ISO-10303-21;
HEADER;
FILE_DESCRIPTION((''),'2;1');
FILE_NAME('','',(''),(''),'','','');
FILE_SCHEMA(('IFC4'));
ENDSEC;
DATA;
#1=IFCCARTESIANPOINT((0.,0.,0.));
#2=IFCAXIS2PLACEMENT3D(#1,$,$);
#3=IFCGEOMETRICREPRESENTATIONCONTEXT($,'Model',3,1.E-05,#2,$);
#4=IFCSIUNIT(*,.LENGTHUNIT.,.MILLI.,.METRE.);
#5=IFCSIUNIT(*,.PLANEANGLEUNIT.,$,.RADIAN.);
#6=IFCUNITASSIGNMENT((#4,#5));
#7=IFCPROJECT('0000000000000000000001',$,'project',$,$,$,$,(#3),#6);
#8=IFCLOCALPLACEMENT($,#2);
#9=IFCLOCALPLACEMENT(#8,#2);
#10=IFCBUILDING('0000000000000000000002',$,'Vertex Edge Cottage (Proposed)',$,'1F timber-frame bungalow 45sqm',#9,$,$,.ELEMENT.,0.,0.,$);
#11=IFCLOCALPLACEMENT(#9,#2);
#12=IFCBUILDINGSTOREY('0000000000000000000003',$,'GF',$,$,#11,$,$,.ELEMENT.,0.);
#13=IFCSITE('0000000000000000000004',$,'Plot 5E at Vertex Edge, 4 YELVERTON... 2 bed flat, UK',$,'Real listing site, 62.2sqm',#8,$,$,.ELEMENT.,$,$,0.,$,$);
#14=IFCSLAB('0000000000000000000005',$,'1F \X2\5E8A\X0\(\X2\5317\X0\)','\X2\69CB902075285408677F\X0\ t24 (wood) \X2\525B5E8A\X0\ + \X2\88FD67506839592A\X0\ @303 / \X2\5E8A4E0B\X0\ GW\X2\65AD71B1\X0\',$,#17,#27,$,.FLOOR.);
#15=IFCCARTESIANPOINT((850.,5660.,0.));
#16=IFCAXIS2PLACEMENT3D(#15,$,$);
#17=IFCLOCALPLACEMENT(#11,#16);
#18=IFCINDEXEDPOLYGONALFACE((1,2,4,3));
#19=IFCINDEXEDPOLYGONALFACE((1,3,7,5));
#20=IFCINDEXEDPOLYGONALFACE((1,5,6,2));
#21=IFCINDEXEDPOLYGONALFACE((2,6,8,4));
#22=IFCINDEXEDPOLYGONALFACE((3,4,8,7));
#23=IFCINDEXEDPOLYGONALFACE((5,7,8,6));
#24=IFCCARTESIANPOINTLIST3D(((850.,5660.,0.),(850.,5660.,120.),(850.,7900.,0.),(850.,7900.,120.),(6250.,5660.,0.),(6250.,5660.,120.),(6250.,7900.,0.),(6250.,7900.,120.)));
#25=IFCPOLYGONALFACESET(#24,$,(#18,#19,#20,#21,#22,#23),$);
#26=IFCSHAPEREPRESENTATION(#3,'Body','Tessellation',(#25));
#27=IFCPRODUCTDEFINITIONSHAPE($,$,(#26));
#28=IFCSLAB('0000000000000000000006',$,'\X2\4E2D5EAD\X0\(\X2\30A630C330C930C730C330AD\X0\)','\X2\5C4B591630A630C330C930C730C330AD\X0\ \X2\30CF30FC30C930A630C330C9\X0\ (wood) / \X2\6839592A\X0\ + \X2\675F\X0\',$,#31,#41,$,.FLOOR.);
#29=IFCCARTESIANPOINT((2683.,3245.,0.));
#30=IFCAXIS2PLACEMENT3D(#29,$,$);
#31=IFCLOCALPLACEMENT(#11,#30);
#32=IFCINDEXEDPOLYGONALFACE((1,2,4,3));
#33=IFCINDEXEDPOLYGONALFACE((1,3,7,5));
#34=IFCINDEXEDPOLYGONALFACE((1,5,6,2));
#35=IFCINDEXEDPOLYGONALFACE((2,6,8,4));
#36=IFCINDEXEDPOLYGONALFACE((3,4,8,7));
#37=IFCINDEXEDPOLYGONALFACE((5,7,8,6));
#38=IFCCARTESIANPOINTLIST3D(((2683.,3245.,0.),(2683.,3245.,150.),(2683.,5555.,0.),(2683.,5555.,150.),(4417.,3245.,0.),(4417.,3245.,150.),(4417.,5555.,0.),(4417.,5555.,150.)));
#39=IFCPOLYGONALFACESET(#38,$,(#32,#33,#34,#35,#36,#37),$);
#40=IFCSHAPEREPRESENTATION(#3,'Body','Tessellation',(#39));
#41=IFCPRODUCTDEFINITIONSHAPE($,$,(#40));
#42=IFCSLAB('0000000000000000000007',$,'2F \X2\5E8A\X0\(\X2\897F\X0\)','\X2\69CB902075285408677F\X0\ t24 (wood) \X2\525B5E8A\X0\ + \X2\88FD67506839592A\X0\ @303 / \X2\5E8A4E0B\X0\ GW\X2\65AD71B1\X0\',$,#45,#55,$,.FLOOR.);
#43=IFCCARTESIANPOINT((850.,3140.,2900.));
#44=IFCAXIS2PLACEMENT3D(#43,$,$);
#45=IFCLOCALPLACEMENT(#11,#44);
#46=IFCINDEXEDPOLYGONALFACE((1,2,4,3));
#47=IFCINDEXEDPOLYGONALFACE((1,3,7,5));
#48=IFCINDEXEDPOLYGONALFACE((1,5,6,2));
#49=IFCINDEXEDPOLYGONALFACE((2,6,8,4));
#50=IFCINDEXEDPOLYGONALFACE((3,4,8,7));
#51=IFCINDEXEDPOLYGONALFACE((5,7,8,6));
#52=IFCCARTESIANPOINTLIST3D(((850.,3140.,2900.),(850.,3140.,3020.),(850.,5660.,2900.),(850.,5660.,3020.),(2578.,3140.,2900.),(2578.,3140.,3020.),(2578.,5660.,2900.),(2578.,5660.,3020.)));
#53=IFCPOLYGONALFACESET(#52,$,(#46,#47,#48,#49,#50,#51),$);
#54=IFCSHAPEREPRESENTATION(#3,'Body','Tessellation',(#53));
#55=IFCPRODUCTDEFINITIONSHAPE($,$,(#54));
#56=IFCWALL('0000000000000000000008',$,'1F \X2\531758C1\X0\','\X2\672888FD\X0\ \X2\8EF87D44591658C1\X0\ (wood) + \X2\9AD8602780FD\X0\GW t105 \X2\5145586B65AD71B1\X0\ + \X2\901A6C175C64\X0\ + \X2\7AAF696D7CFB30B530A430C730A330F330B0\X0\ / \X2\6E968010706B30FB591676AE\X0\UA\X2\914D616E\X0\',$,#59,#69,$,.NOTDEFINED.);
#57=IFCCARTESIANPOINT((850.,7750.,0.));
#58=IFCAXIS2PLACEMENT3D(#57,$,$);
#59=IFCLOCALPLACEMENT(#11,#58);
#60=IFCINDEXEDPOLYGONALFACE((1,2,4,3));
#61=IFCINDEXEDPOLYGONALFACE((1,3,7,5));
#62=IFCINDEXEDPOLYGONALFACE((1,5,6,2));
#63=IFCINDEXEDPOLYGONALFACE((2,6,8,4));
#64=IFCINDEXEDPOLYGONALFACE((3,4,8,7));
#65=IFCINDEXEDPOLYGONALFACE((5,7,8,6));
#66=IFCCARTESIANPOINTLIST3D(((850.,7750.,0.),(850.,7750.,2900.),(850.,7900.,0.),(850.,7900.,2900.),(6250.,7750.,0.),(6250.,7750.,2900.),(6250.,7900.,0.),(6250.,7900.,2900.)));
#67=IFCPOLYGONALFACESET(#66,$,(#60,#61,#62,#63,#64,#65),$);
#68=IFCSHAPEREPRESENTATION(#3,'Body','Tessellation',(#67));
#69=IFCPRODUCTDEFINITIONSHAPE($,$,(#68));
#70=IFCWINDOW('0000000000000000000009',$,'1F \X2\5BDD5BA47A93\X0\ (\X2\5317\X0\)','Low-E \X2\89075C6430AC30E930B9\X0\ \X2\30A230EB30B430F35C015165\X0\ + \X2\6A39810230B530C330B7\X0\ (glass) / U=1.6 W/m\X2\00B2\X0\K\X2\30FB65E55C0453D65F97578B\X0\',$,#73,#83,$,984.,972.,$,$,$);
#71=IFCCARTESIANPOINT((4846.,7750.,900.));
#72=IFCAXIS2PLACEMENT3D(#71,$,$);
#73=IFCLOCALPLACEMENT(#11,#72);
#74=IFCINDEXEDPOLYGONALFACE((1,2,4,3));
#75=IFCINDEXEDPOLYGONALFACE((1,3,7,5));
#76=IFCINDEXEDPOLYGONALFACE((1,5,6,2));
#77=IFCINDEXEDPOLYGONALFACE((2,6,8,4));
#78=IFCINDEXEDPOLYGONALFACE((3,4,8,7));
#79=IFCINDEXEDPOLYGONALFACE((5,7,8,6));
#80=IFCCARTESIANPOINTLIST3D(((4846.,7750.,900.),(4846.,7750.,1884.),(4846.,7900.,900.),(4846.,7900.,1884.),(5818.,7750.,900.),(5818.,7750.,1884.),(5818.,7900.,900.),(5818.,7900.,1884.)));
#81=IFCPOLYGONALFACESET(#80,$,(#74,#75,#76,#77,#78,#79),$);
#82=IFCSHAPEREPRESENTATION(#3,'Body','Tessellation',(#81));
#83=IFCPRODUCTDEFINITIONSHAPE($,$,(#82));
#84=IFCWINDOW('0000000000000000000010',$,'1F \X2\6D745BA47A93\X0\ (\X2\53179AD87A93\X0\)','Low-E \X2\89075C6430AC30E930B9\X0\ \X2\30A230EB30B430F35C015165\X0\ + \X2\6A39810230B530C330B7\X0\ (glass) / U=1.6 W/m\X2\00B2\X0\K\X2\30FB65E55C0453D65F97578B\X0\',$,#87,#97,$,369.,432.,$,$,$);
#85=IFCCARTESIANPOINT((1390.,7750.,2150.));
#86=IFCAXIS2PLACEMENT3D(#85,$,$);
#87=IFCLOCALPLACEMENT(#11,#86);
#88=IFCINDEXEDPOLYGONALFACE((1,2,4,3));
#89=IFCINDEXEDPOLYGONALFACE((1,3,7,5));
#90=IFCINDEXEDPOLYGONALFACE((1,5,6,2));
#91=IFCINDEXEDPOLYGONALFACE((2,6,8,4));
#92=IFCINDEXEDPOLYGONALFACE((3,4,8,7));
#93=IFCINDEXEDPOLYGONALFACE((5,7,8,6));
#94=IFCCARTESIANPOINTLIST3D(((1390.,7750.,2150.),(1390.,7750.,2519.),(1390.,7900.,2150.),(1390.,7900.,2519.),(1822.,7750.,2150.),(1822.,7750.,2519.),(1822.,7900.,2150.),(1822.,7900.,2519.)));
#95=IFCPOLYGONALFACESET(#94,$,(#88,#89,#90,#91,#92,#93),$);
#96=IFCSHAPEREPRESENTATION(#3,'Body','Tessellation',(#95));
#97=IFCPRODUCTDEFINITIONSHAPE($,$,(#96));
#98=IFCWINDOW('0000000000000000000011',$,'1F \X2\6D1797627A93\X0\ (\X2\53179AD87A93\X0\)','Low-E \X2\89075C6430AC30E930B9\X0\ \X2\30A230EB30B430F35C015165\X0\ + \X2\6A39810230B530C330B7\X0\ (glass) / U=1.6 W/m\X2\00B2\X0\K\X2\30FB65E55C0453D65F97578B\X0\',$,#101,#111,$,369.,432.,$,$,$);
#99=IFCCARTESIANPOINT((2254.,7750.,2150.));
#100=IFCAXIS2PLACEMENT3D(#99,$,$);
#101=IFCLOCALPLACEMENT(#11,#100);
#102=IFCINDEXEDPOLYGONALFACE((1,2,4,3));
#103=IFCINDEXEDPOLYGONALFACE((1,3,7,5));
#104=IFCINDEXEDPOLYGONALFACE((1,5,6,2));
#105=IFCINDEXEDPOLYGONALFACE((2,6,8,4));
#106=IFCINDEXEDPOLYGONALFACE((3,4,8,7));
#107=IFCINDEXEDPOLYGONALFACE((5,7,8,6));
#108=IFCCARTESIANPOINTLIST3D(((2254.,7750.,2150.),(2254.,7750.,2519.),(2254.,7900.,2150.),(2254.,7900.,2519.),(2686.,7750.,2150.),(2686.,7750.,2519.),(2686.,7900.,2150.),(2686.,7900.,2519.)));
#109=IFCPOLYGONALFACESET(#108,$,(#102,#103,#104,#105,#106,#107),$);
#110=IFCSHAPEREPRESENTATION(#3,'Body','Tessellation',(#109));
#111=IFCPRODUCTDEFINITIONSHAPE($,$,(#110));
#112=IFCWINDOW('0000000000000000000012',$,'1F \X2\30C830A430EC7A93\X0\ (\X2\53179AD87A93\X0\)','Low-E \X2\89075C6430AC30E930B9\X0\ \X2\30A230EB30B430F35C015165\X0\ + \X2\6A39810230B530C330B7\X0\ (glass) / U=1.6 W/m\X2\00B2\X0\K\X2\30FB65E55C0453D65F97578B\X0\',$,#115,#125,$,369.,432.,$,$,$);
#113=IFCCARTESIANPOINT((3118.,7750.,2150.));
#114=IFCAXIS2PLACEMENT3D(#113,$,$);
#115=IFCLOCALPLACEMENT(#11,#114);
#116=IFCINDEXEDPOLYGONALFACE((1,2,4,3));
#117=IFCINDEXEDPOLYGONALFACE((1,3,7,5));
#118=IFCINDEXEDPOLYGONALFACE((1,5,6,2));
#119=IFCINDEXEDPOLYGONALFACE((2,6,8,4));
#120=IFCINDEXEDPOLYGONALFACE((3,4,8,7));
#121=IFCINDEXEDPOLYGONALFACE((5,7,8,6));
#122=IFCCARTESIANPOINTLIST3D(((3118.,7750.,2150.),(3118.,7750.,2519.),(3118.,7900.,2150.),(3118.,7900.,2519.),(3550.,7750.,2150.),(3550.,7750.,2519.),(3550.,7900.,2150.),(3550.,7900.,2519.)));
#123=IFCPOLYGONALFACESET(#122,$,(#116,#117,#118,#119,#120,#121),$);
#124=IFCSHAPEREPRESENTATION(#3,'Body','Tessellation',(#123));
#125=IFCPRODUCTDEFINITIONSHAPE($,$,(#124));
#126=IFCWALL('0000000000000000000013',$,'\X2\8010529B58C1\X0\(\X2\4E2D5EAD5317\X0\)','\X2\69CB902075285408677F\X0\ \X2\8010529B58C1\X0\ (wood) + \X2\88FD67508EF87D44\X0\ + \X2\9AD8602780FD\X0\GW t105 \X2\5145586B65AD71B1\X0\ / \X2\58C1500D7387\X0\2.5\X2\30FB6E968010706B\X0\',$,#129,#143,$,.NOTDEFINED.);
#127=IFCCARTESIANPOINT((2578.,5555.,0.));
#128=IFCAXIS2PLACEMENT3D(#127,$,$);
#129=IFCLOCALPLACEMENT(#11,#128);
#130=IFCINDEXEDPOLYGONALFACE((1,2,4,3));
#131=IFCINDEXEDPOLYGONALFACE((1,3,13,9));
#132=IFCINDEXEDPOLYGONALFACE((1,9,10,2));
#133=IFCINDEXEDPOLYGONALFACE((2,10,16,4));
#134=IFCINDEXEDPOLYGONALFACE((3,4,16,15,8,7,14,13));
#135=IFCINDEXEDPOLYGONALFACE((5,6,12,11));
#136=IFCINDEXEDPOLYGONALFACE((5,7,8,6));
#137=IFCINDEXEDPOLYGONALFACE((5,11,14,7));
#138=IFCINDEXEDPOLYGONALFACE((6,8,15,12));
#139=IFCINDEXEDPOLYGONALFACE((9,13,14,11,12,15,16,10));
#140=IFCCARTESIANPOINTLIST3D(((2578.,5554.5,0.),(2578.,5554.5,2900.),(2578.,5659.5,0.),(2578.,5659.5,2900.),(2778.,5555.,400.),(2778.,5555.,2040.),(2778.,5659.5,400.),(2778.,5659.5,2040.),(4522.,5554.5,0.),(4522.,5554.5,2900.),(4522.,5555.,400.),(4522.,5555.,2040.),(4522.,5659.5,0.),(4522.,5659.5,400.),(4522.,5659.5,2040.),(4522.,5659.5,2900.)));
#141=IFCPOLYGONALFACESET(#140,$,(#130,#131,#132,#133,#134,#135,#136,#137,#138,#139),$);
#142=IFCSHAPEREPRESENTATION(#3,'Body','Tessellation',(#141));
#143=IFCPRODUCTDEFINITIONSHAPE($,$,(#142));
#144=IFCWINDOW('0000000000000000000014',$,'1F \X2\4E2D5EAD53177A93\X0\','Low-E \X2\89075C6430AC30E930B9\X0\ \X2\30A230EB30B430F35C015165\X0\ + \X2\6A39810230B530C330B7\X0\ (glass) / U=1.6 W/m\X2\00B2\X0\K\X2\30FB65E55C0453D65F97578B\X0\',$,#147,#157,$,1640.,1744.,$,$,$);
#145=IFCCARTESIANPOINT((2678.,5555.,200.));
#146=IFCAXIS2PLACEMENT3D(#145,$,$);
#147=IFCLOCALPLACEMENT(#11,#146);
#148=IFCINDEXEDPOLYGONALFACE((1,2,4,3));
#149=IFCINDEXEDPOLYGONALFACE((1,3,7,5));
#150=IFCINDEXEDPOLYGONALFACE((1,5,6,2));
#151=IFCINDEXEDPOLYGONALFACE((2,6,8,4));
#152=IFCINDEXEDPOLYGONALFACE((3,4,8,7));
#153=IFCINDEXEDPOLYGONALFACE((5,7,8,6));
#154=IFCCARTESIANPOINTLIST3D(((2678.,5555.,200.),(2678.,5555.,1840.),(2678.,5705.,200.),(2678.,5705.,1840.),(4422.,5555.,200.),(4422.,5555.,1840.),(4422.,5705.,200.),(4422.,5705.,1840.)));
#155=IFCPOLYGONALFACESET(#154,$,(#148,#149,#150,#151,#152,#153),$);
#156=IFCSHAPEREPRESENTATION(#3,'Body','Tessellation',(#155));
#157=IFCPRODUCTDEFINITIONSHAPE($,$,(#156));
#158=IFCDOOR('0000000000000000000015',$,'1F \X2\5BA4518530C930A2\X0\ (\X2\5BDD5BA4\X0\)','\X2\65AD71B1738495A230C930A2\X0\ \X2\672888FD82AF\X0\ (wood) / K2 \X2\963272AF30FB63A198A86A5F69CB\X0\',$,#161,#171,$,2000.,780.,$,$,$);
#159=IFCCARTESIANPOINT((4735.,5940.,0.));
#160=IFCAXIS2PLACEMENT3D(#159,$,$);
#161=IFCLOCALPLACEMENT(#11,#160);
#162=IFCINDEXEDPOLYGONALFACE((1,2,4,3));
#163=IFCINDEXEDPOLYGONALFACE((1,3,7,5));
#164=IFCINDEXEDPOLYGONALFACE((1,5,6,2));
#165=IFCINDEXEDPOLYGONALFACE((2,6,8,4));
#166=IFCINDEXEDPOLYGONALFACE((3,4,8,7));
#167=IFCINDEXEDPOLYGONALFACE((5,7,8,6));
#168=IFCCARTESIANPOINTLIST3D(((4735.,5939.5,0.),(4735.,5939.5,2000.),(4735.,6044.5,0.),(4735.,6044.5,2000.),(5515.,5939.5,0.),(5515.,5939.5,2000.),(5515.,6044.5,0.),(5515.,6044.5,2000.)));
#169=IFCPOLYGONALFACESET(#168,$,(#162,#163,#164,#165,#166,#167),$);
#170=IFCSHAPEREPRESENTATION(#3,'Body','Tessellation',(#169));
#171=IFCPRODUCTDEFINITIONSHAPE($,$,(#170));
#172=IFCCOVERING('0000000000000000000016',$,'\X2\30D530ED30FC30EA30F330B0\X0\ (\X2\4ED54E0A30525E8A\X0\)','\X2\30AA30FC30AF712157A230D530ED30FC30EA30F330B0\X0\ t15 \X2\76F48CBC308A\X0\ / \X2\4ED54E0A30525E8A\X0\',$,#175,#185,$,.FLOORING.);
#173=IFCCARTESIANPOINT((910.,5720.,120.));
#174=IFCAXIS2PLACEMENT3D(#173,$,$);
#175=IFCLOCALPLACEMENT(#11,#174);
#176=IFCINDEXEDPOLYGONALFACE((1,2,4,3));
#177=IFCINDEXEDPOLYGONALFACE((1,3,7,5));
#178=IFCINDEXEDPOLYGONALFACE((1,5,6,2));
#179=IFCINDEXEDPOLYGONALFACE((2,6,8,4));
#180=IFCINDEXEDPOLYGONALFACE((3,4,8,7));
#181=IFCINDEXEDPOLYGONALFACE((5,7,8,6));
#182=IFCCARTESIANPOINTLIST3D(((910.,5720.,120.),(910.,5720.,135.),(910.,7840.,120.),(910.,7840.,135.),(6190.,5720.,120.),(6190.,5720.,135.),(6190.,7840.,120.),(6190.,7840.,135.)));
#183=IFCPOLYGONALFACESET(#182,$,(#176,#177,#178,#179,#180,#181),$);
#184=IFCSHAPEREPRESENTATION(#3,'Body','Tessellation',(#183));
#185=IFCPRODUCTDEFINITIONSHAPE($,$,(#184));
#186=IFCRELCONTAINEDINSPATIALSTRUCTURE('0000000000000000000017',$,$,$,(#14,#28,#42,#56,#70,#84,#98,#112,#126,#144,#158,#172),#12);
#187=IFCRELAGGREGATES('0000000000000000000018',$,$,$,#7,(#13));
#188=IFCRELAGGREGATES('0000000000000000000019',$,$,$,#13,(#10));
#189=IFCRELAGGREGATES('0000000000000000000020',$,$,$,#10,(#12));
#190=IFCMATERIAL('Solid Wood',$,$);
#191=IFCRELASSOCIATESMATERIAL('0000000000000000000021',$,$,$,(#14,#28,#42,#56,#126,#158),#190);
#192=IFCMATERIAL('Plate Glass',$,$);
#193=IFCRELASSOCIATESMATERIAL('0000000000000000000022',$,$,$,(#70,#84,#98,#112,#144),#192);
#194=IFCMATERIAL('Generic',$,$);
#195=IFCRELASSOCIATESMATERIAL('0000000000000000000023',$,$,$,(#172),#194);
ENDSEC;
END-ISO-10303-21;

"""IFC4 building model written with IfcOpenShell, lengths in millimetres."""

from ifc_helpers import new_model, si_unit, frame, frame_2d, origin, place, context, project, spatial, rectangle, extrude, material, element, fill, save


model = new_model("IFC4")

# Units and contexts
model_context = context("Model", 3, precision=1e-05, world=origin())
ifc_project = project(units=[si_unit("LENGTHUNIT", "METRE", prefix="MILLI"), si_unit("PLANEANGLEUNIT", "RADIAN")], contexts=[model_context])

# Site, building, storey
site_placement = place(None, origin())
site = spatial("IfcSite", under=ifc_project, at=site_placement, Name="Plot 5E at Vertex Edge, 4 YELVERTON... 2 bed flat, UK", ObjectType="Real listing site, 62.2sqm", CompositionType="ELEMENT", RefElevation=0.0)
building_placement = place(site_placement, origin())
building = spatial("IfcBuilding", under=site, at=building_placement, Name="Vertex Edge Cottage (Proposed)", ObjectType="1F timber-frame bungalow 45sqm", CompositionType="ELEMENT", ElevationOfRefHeight=0.0, ElevationOfTerrain=0.0)
storey_placement = place(building_placement, origin())
storey = spatial("IfcBuildingStorey", under=building, at=storey_placement, Name="GF", CompositionType="ELEMENT", Elevation=0.0)

# Slabs
ifc_material_1 = material(Name="Solid Wood")
slab_1_placement = place(storey_placement, frame((850.0, 5660.0, 0.0)))
element("IfcSlab", 1, at=slab_1_placement, inside=storey, material=ifc_material_1, Name="1F 床(北)", Description="構造用合板 t24 (wood) 剛床 + 製材根太 @303 / 床下 GW断熱", PredefinedType="FLOOR", context=model_context, shape_type="SweptSolid", body=[
    extrude(rectangle(XDim=5400.0, YDim=2240.0, at=frame_2d((2700.0, 1120.0))), frame((850.0, 5660.0, 0.0)), (0.0, 0.0, 1.0), 120.0),
])
slab_2_placement = place(storey_placement, frame((2683.0, 3245.0, 0.0)))
element("IfcSlab", 2, at=slab_2_placement, inside=storey, material=ifc_material_1, Name="中庭(ウッドデッキ)", Description="屋外ウッドデッキ ハードウッド (wood) / 根太 + 束", PredefinedType="FLOOR", context=model_context, shape_type="SweptSolid", body=[
    extrude(rectangle(XDim=1734.0, YDim=2310.0, at=frame_2d((867.0, 1155.0))), frame((2683.0, 3245.0, 0.0)), (0.0, 0.0, 1.0), 150.0),
])
slab_3_placement = place(storey_placement, frame((850.0, 3140.0, 2900.0)))
element("IfcSlab", 3, at=slab_3_placement, inside=storey, material=ifc_material_1, Name="2F 床(西)", Description="構造用合板 t24 (wood) 剛床 + 製材根太 @303 / 床下 GW断熱", PredefinedType="FLOOR", context=model_context, shape_type="SweptSolid", body=[
    extrude(rectangle(XDim=1728.0, YDim=2520.0, at=frame_2d((864.0, 1260.0))), frame((850.0, 3140.0, 2900.0)), (0.0, 0.0, 1.0), 120.0),
])

# Wall, openings, windows
wall_1_placement = place(storey_placement, frame((850.0, 7750.0, 0.0)))
wall_1 = element("IfcWall", 4, at=wall_1_placement, inside=storey, material=ifc_material_1, Name="1F 北壁", Description="木製 軸組外壁 (wood) + 高性能GW t105 充填断熱 + 通気層 + 窯業系サイディング / 準耐火・外皮UA配慮", PredefinedType="NOTDEFINED", context=model_context, shape_type="SweptSolid", body=[
    extrude(rectangle(XDim=5400.0, YDim=150.0, at=frame_2d((2700.0, 75.0))), frame((850.0, 7750.0, 0.0)), (0.0, 0.0, 1.0), 2900.0),
])
opening_1_placement = place(storey_placement, frame((4846.0, 7750.0, 900.0)))
opening_1 = element("IfcOpeningElement", 5, at=opening_1_placement, cuts=wall_1, PredefinedType="NOTDEFINED", context=model_context, shape_type="SweptSolid", body=[
    extrude(rectangle(XDim=972.0, YDim=150.0, at=frame_2d((486.0, 75.0))), frame((4846.0, 7750.0, 900.0)), (0.0, 0.0, 1.0), 984.0),
])
opening_2_placement = place(storey_placement, frame((1390.0, 7750.0, 2150.0)))
opening_2 = element("IfcOpeningElement", 6, at=opening_2_placement, cuts=wall_1, PredefinedType="NOTDEFINED", context=model_context, shape_type="SweptSolid", body=[
    extrude(rectangle(XDim=432.0, YDim=150.0, at=frame_2d((216.0, 75.0))), frame((1390.0, 7750.0, 2150.0)), (0.0, 0.0, 1.0), 369.0),
])
opening_3_placement = place(storey_placement, frame((2254.0, 7750.0, 2150.0)))
opening_3 = element("IfcOpeningElement", 7, at=opening_3_placement, cuts=wall_1, PredefinedType="NOTDEFINED", context=model_context, shape_type="SweptSolid", body=[
    extrude(rectangle(XDim=432.0, YDim=150.0, at=frame_2d((216.0, 75.0))), frame((2254.0, 7750.0, 2150.0)), (0.0, 0.0, 1.0), 369.0),
])
opening_4_placement = place(storey_placement, frame((3118.0, 7750.0, 2150.0)))
opening_4 = element("IfcOpeningElement", 8, at=opening_4_placement, cuts=wall_1, PredefinedType="NOTDEFINED", context=model_context, shape_type="SweptSolid", body=[
    extrude(rectangle(XDim=432.0, YDim=150.0, at=frame_2d((216.0, 75.0))), frame((3118.0, 7750.0, 2150.0)), (0.0, 0.0, 1.0), 369.0),
])
ifc_material_2 = material(Name="Plate Glass")
window_1_placement = place(storey_placement, frame((4846.0, 7750.0, 900.0)))
window_1 = element("IfcWindow", 9, at=window_1_placement, inside=storey, material=ifc_material_2, Name="1F 寝室窓 (北)", Description="Low-E 複層ガラス アルゴン封入 + 樹脂サッシ (glass) / U=1.6 W/m²K・日射取得型", OverallHeight=984.0, OverallWidth=972.0, context=model_context, shape_type="SweptSolid", body=[
    extrude(rectangle(XDim=972.0, YDim=150.0, at=frame_2d((486.0, 75.0))), frame((4846.0, 7750.0, 900.0)), (0.0, 0.0, 1.0), 984.0),
])
fill(opening_1, window_1)
window_2_placement = place(storey_placement, frame((1390.0, 7750.0, 2150.0)))
window_2 = element("IfcWindow", 10, at=window_2_placement, inside=storey, material=ifc_material_2, Name="1F 浴室窓 (北高窓)", Description="Low-E 複層ガラス アルゴン封入 + 樹脂サッシ (glass) / U=1.6 W/m²K・日射取得型", OverallHeight=369.0, OverallWidth=432.0, context=model_context, shape_type="SweptSolid", body=[
    extrude(rectangle(XDim=432.0, YDim=150.0, at=frame_2d((216.0, 75.0))), frame((1390.0, 7750.0, 2150.0)), (0.0, 0.0, 1.0), 369.0),
])
fill(opening_2, window_2)
window_3_placement = place(storey_placement, frame((2254.0, 7750.0, 2150.0)))
window_3 = element("IfcWindow", 11, at=window_3_placement, inside=storey, material=ifc_material_2, Name="1F 洗面窓 (北高窓)", Description="Low-E 複層ガラス アルゴン封入 + 樹脂サッシ (glass) / U=1.6 W/m²K・日射取得型", OverallHeight=369.0, OverallWidth=432.0, context=model_context, shape_type="SweptSolid", body=[
    extrude(rectangle(XDim=432.0, YDim=150.0, at=frame_2d((216.0, 75.0))), frame((2254.0, 7750.0, 2150.0)), (0.0, 0.0, 1.0), 369.0),
])
fill(opening_3, window_3)
window_4_placement = place(storey_placement, frame((3118.0, 7750.0, 2150.0)))
window_4 = element("IfcWindow", 12, at=window_4_placement, inside=storey, material=ifc_material_2, Name="1F トイレ窓 (北高窓)", Description="Low-E 複層ガラス アルゴン封入 + 樹脂サッシ (glass) / U=1.6 W/m²K・日射取得型", OverallHeight=369.0, OverallWidth=432.0, context=model_context, shape_type="SweptSolid", body=[
    extrude(rectangle(XDim=432.0, YDim=150.0, at=frame_2d((216.0, 75.0))), frame((3118.0, 7750.0, 2150.0)), (0.0, 0.0, 1.0), 369.0),
])
fill(opening_4, window_4)

# Wall, opening, window
wall_2_placement = place(storey_placement, frame((2578.0, 5555.0, 0.0)))
wall_2 = element("IfcWall", 13, at=wall_2_placement, inside=storey, material=ifc_material_1, Name="耐力壁(中庭北)", Description="構造用合板 耐力壁 (wood) + 製材軸組 + 高性能GW t105 充填断熱 / 壁倍率2.5・準耐火", PredefinedType="NOTDEFINED", context=model_context, shape_type="SweptSolid", body=[
    extrude(rectangle(XDim=1944.0, YDim=105.0, at=frame_2d((972.0, 52.0))), frame((2578.0, 5555.0, 0.0)), (0.0, 0.0, 1.0), 2900.0),
])
opening_5_placement = place(storey_placement, frame((2678.0, 5555.0, 200.0)))
opening_5 = element("IfcOpeningElement", 14, at=opening_5_placement, cuts=wall_2, PredefinedType="NOTDEFINED", context=model_context, shape_type="SweptSolid", body=[
    extrude(rectangle(XDim=1744.0, YDim=150.0, at=frame_2d((872.0, 75.0))), frame((2678.0, 5555.0, 200.0)), (0.0, 0.0, 1.0), 1640.0),
])
window_5_placement = place(storey_placement, frame((2678.0, 5555.0, 200.0)))
window_5 = element("IfcWindow", 15, at=window_5_placement, inside=storey, material=ifc_material_2, Name="1F 中庭北窓", Description="Low-E 複層ガラス アルゴン封入 + 樹脂サッシ (glass) / U=1.6 W/m²K・日射取得型", OverallHeight=1640.0, OverallWidth=1744.0, context=model_context, shape_type="SweptSolid", body=[
    extrude(rectangle(XDim=1744.0, YDim=150.0, at=frame_2d((872.0, 75.0))), frame((2678.0, 5555.0, 200.0)), (0.0, 0.0, 1.0), 1640.0),
])
fill(opening_5, window_5)

# Door
door_1_placement = place(storey_placement, frame((4735.0, 5940.0, 0.0)))
element("IfcDoor", 16, at=door_1_placement, inside=storey, material=ifc_material_1, Name="1F 室内ドア (寝室)", Description="断熱玄関ドア 木製芯 (wood) / K2 防犯・採風機構", OverallHeight=2000.0, OverallWidth=780.0, context=model_context, shape_type="SweptSolid", body=[
    extrude(rectangle(XDim=780.0, YDim=105.0, at=frame_2d((390.0, 52.0))), frame((4735.0, 5940.0, 0.0)), (0.0, 0.0, 1.0), 2000.0),
])

# Covering
ifc_material_3 = material(Name="Generic")
covering_1_placement = place(storey_placement, frame((910.0, 5720.0, 120.0)))
element("IfcCovering", 17, at=covering_1_placement, inside=storey, material=ifc_material_3, Name="フローリング (仕上げ床)", Description="オーク無垢フローリング t15 直貼り / 仕上げ床", PredefinedType="FLOORING", context=model_context, shape_type="SweptSolid", body=[
    extrude(rectangle(XDim=5280.0, YDim=2120.0, at=frame_2d((2640.0, 1060.0))), frame((910.0, 5720.0, 120.0)), (0.0, 0.0, 1.0), 15.0),
])

save(model, "model.ifc")
